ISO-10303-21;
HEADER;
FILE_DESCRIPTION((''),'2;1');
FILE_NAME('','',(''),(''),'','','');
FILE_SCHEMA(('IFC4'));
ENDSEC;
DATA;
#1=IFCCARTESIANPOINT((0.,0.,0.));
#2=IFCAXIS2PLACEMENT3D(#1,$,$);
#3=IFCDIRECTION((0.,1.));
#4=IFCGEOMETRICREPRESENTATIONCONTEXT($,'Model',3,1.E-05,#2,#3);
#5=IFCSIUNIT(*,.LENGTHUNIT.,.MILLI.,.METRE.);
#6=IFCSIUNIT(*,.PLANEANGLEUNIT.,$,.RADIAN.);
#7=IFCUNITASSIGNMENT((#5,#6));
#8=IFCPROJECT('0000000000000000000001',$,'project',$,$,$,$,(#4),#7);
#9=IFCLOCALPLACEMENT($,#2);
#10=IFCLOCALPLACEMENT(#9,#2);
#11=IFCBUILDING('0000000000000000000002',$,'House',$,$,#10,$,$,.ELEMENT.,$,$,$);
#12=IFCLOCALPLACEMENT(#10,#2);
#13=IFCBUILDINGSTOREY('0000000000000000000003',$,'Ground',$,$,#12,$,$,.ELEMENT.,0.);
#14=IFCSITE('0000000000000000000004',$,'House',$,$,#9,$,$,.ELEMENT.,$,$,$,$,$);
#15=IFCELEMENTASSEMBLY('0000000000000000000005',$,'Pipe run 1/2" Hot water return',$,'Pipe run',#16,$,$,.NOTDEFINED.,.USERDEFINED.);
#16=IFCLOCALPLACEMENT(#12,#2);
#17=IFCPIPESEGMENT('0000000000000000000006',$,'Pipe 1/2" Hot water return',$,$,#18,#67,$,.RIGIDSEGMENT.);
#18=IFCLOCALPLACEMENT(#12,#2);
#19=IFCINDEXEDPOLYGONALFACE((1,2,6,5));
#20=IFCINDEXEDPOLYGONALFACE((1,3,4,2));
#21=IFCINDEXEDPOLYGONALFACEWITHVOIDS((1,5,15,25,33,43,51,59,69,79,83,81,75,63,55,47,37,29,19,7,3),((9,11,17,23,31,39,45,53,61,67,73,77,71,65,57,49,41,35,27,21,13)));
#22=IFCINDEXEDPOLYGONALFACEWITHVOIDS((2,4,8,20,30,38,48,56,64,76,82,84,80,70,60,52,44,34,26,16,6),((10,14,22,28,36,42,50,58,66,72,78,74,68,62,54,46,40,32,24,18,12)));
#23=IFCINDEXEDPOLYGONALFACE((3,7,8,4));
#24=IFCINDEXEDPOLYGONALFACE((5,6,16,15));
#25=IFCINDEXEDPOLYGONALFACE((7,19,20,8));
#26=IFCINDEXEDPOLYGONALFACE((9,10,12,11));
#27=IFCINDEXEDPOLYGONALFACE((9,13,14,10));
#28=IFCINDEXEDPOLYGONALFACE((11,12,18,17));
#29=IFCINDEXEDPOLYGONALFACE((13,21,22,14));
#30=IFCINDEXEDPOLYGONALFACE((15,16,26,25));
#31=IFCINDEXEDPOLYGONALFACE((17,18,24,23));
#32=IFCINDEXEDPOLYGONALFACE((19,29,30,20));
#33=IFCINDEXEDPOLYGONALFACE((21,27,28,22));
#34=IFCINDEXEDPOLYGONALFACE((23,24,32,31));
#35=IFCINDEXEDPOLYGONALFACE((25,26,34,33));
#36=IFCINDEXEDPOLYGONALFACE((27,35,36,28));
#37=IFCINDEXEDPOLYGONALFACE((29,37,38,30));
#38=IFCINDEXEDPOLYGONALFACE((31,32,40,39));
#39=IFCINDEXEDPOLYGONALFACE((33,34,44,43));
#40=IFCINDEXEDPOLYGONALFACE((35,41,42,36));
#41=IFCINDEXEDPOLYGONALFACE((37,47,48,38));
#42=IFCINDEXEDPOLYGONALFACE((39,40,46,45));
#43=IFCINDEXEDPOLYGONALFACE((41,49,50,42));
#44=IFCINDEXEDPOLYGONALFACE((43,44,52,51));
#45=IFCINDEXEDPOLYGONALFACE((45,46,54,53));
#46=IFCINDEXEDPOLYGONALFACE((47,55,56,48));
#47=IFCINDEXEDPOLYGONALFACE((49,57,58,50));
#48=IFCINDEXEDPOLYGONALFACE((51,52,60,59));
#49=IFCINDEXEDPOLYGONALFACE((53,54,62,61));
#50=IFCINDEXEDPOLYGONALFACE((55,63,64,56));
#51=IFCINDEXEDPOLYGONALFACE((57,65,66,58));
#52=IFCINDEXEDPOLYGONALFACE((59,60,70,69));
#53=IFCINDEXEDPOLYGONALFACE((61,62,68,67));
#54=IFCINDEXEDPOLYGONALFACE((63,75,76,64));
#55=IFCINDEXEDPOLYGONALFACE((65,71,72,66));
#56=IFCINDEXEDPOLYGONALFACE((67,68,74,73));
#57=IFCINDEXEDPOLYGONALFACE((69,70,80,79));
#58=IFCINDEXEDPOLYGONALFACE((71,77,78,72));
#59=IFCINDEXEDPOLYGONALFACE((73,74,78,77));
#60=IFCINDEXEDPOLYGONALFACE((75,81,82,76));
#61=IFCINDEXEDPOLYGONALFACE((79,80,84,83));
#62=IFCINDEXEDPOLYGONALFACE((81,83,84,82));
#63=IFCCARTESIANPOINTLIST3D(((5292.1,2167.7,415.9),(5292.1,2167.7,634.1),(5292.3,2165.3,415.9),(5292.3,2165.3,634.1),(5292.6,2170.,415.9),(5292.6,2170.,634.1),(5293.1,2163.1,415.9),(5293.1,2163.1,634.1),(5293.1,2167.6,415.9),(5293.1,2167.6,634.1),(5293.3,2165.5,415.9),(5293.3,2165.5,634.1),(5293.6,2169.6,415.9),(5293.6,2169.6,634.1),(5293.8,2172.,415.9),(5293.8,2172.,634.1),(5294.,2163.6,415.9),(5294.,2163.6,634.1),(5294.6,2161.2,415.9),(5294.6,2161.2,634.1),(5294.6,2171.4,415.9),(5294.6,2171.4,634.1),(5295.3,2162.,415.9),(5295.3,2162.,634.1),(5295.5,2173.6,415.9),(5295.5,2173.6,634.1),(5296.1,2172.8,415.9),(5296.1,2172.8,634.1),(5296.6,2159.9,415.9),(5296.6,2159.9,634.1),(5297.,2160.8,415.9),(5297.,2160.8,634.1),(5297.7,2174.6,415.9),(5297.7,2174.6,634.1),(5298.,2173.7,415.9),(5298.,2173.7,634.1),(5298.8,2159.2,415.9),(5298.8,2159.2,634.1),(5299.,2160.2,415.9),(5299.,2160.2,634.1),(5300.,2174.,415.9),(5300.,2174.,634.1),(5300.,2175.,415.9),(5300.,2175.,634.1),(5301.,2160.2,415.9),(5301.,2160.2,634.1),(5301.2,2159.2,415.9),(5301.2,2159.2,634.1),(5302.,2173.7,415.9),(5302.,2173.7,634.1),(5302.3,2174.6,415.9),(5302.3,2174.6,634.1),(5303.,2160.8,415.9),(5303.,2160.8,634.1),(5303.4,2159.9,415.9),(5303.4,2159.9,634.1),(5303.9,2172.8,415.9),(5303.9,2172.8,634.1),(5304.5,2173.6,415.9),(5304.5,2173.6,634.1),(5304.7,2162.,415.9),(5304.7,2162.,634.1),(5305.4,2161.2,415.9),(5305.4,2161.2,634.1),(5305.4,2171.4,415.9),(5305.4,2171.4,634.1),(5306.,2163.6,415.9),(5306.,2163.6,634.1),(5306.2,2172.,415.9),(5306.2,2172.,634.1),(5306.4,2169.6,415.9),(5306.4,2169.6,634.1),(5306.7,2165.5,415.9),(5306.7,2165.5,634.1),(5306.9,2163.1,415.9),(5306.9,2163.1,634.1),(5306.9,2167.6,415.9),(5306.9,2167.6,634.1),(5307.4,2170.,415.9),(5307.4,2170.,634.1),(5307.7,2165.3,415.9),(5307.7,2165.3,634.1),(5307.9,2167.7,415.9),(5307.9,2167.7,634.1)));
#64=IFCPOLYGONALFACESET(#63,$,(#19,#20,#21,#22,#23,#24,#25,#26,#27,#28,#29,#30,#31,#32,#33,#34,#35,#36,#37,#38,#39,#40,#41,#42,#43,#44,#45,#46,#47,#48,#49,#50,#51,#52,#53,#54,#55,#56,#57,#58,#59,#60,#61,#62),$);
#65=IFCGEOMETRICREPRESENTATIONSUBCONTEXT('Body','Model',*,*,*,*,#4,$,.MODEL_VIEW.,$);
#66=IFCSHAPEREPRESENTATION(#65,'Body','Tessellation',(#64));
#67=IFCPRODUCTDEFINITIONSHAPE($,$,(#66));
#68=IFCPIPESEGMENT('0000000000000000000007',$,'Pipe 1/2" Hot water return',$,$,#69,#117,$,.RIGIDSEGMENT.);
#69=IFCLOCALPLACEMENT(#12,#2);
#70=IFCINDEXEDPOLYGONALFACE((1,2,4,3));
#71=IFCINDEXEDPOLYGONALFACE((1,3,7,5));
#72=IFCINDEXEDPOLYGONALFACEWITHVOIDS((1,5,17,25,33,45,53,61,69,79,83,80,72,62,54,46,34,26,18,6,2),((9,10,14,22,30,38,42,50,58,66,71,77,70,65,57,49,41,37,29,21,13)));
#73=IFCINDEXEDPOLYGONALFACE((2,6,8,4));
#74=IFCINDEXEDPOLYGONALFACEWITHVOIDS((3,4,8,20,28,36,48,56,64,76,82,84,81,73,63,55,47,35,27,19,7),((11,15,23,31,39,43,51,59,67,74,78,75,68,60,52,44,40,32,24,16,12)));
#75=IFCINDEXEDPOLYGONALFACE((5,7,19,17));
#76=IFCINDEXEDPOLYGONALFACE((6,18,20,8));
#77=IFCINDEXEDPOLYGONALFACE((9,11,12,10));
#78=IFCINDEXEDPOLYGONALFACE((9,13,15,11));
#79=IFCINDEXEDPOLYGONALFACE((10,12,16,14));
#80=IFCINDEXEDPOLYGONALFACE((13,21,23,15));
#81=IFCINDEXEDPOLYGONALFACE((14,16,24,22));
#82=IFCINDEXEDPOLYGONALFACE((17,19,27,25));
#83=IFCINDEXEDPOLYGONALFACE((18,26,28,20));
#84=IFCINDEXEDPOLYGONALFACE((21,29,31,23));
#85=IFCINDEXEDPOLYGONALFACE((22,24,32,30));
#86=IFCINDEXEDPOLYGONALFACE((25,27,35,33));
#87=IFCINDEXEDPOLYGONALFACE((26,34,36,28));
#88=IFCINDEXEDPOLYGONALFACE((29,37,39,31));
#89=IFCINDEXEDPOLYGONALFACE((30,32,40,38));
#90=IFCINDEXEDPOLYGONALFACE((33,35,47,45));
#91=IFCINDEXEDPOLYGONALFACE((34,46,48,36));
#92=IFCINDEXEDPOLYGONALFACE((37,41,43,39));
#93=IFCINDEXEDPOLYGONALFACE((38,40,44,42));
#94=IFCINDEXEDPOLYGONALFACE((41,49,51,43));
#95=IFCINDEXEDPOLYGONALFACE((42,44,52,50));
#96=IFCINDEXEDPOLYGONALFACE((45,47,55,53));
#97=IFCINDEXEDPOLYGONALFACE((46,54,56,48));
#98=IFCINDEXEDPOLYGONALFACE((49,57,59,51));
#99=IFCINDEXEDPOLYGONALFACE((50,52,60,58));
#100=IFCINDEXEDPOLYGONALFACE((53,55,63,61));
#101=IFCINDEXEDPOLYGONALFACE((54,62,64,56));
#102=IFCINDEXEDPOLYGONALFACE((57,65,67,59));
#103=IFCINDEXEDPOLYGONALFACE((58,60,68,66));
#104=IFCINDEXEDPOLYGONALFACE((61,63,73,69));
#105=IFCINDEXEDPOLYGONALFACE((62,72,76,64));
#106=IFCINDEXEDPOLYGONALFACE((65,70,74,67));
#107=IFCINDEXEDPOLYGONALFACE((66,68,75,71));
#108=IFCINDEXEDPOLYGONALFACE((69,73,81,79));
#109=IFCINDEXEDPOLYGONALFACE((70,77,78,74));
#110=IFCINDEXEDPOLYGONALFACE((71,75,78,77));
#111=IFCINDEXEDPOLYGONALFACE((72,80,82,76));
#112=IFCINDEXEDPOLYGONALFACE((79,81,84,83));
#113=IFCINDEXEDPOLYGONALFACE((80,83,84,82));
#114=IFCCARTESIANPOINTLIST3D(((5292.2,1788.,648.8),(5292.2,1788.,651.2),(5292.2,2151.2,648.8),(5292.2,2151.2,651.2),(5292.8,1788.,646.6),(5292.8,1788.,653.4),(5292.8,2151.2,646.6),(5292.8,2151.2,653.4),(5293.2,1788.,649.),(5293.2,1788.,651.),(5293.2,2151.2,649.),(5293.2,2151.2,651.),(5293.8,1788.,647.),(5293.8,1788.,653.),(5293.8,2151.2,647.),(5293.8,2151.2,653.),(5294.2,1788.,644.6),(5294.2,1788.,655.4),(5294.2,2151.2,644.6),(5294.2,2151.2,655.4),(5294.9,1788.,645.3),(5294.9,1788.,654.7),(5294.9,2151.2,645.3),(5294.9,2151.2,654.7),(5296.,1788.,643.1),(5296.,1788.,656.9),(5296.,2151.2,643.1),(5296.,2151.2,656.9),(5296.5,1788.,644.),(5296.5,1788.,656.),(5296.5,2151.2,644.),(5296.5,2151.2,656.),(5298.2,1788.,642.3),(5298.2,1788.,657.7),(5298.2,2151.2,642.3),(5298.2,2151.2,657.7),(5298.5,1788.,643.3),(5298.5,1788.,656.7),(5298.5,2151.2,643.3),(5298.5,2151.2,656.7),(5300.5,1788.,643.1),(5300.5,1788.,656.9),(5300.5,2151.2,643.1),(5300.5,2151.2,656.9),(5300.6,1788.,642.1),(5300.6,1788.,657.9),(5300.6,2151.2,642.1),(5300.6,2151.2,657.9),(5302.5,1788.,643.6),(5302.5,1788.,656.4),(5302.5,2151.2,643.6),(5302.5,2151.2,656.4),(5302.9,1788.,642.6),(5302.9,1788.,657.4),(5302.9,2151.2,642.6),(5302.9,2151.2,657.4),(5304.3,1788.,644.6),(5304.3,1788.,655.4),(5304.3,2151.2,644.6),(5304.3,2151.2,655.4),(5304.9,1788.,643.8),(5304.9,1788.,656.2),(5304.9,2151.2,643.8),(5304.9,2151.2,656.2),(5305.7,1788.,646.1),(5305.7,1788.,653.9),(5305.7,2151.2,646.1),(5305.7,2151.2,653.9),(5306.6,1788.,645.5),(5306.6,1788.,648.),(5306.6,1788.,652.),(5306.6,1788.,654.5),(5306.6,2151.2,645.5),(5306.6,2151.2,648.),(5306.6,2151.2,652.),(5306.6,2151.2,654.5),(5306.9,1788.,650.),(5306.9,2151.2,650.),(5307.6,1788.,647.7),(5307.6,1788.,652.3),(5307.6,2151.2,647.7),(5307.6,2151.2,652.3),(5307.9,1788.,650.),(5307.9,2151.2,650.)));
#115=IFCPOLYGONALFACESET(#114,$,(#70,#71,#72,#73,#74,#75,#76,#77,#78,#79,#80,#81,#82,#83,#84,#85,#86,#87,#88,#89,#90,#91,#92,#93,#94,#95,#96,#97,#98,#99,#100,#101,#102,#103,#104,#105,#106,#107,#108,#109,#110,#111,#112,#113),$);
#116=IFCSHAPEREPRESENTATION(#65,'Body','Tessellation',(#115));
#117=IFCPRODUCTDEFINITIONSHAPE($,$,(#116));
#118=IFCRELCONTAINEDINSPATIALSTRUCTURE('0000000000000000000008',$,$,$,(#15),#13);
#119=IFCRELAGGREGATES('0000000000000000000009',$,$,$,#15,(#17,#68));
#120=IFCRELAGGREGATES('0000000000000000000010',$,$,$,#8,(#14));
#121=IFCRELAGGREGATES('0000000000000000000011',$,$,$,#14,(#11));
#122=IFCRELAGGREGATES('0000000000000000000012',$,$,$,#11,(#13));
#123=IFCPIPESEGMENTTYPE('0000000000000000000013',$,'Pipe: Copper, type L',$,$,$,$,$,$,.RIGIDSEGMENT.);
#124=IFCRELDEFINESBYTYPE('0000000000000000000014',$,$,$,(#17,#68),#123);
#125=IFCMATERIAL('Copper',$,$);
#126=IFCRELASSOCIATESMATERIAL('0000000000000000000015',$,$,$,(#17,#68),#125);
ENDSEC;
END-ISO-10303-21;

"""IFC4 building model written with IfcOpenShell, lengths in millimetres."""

from ifc_helpers import new_model, si_unit, direction, frame, origin, origin_with_axes, origin_2d, place, context, subcontext, project, spatial, hollow_circle, extrude, material, type_object, element, aggregate, save


model = new_model("IFC4")

# Units and contexts
model_context = context("Model", 3, precision=1e-05, world=origin(), true_north=direction((0.0, 1.0)))
body_context = subcontext(model_context, "Body", "Model", "MODEL_VIEW")
ifc_project = project(units=[si_unit("LENGTHUNIT", "METRE", prefix="MILLI"), si_unit("PLANEANGLEUNIT", "RADIAN")], contexts=[model_context])

# Site, building, storey
site_placement = place(None, origin())
site = spatial("IfcSite", under=ifc_project, at=site_placement, Name="House", CompositionType="ELEMENT")
building_placement = place(site_placement, origin())
building = spatial("IfcBuilding", under=site, at=building_placement, Name="House", CompositionType="ELEMENT")
storey_placement = place(building_placement, origin())
storey = spatial("IfcBuildingStorey", under=building, at=storey_placement, Name="Ground", CompositionType="ELEMENT", Elevation=0.0)

# Element assembly, pipe segments
ifc_material = material(Name="Copper")
pipe_segment_type = type_object("IfcPipeSegmentType", Name="Pipe: Copper, type L", PredefinedType="RIGIDSEGMENT")
assembly_1_placement = place(storey_placement, origin_with_axes())
assembly_1 = element("IfcElementAssembly", 1, at=assembly_1_placement, inside=storey, Name="Pipe run 1/2\" Hot water return", ObjectType="Pipe run", AssemblyPlace="NOTDEFINED", PredefinedType="USERDEFINED")
pipe_segment_1_placement = place(storey_placement, origin_with_axes())
pipe_segment_1 = element("IfcPipeSegment", 2, at=pipe_segment_1_placement, type_object=pipe_segment_type, material=ifc_material, Name="Pipe 1/2\" Hot water return", PredefinedType="RIGIDSEGMENT", context=body_context, shape_type="SweptSolid", body=[
    extrude(hollow_circle(Radius=7.9, WallThickness=1.0, at=origin_2d()), frame((5300.0, 2167.1, 415.9), z_axis=(0.0, 0.0, 1.0), x_axis=(0.0, 1.0, 0.0)), (0.0, 0.0, 1.0), 218.2),
])
pipe_segment_2_placement = place(storey_placement, origin_with_axes())
pipe_segment_2 = element("IfcPipeSegment", 3, at=pipe_segment_2_placement, type_object=pipe_segment_type, material=ifc_material, Name="Pipe 1/2\" Hot water return", PredefinedType="RIGIDSEGMENT", context=body_context, shape_type="SweptSolid", body=[
    extrude(hollow_circle(Radius=7.9, WallThickness=1.0, at=origin_2d()), frame((5300.0, 2151.2, 650.0), z_axis=(0.0, -1.0, 0.0), x_axis=(1.0, 0.0, 0.0)), (0.0, 0.0, 1.0), 363.2),
])

aggregate(assembly_1, [pipe_segment_1, pipe_segment_2])

save(model, "model.ifc")
